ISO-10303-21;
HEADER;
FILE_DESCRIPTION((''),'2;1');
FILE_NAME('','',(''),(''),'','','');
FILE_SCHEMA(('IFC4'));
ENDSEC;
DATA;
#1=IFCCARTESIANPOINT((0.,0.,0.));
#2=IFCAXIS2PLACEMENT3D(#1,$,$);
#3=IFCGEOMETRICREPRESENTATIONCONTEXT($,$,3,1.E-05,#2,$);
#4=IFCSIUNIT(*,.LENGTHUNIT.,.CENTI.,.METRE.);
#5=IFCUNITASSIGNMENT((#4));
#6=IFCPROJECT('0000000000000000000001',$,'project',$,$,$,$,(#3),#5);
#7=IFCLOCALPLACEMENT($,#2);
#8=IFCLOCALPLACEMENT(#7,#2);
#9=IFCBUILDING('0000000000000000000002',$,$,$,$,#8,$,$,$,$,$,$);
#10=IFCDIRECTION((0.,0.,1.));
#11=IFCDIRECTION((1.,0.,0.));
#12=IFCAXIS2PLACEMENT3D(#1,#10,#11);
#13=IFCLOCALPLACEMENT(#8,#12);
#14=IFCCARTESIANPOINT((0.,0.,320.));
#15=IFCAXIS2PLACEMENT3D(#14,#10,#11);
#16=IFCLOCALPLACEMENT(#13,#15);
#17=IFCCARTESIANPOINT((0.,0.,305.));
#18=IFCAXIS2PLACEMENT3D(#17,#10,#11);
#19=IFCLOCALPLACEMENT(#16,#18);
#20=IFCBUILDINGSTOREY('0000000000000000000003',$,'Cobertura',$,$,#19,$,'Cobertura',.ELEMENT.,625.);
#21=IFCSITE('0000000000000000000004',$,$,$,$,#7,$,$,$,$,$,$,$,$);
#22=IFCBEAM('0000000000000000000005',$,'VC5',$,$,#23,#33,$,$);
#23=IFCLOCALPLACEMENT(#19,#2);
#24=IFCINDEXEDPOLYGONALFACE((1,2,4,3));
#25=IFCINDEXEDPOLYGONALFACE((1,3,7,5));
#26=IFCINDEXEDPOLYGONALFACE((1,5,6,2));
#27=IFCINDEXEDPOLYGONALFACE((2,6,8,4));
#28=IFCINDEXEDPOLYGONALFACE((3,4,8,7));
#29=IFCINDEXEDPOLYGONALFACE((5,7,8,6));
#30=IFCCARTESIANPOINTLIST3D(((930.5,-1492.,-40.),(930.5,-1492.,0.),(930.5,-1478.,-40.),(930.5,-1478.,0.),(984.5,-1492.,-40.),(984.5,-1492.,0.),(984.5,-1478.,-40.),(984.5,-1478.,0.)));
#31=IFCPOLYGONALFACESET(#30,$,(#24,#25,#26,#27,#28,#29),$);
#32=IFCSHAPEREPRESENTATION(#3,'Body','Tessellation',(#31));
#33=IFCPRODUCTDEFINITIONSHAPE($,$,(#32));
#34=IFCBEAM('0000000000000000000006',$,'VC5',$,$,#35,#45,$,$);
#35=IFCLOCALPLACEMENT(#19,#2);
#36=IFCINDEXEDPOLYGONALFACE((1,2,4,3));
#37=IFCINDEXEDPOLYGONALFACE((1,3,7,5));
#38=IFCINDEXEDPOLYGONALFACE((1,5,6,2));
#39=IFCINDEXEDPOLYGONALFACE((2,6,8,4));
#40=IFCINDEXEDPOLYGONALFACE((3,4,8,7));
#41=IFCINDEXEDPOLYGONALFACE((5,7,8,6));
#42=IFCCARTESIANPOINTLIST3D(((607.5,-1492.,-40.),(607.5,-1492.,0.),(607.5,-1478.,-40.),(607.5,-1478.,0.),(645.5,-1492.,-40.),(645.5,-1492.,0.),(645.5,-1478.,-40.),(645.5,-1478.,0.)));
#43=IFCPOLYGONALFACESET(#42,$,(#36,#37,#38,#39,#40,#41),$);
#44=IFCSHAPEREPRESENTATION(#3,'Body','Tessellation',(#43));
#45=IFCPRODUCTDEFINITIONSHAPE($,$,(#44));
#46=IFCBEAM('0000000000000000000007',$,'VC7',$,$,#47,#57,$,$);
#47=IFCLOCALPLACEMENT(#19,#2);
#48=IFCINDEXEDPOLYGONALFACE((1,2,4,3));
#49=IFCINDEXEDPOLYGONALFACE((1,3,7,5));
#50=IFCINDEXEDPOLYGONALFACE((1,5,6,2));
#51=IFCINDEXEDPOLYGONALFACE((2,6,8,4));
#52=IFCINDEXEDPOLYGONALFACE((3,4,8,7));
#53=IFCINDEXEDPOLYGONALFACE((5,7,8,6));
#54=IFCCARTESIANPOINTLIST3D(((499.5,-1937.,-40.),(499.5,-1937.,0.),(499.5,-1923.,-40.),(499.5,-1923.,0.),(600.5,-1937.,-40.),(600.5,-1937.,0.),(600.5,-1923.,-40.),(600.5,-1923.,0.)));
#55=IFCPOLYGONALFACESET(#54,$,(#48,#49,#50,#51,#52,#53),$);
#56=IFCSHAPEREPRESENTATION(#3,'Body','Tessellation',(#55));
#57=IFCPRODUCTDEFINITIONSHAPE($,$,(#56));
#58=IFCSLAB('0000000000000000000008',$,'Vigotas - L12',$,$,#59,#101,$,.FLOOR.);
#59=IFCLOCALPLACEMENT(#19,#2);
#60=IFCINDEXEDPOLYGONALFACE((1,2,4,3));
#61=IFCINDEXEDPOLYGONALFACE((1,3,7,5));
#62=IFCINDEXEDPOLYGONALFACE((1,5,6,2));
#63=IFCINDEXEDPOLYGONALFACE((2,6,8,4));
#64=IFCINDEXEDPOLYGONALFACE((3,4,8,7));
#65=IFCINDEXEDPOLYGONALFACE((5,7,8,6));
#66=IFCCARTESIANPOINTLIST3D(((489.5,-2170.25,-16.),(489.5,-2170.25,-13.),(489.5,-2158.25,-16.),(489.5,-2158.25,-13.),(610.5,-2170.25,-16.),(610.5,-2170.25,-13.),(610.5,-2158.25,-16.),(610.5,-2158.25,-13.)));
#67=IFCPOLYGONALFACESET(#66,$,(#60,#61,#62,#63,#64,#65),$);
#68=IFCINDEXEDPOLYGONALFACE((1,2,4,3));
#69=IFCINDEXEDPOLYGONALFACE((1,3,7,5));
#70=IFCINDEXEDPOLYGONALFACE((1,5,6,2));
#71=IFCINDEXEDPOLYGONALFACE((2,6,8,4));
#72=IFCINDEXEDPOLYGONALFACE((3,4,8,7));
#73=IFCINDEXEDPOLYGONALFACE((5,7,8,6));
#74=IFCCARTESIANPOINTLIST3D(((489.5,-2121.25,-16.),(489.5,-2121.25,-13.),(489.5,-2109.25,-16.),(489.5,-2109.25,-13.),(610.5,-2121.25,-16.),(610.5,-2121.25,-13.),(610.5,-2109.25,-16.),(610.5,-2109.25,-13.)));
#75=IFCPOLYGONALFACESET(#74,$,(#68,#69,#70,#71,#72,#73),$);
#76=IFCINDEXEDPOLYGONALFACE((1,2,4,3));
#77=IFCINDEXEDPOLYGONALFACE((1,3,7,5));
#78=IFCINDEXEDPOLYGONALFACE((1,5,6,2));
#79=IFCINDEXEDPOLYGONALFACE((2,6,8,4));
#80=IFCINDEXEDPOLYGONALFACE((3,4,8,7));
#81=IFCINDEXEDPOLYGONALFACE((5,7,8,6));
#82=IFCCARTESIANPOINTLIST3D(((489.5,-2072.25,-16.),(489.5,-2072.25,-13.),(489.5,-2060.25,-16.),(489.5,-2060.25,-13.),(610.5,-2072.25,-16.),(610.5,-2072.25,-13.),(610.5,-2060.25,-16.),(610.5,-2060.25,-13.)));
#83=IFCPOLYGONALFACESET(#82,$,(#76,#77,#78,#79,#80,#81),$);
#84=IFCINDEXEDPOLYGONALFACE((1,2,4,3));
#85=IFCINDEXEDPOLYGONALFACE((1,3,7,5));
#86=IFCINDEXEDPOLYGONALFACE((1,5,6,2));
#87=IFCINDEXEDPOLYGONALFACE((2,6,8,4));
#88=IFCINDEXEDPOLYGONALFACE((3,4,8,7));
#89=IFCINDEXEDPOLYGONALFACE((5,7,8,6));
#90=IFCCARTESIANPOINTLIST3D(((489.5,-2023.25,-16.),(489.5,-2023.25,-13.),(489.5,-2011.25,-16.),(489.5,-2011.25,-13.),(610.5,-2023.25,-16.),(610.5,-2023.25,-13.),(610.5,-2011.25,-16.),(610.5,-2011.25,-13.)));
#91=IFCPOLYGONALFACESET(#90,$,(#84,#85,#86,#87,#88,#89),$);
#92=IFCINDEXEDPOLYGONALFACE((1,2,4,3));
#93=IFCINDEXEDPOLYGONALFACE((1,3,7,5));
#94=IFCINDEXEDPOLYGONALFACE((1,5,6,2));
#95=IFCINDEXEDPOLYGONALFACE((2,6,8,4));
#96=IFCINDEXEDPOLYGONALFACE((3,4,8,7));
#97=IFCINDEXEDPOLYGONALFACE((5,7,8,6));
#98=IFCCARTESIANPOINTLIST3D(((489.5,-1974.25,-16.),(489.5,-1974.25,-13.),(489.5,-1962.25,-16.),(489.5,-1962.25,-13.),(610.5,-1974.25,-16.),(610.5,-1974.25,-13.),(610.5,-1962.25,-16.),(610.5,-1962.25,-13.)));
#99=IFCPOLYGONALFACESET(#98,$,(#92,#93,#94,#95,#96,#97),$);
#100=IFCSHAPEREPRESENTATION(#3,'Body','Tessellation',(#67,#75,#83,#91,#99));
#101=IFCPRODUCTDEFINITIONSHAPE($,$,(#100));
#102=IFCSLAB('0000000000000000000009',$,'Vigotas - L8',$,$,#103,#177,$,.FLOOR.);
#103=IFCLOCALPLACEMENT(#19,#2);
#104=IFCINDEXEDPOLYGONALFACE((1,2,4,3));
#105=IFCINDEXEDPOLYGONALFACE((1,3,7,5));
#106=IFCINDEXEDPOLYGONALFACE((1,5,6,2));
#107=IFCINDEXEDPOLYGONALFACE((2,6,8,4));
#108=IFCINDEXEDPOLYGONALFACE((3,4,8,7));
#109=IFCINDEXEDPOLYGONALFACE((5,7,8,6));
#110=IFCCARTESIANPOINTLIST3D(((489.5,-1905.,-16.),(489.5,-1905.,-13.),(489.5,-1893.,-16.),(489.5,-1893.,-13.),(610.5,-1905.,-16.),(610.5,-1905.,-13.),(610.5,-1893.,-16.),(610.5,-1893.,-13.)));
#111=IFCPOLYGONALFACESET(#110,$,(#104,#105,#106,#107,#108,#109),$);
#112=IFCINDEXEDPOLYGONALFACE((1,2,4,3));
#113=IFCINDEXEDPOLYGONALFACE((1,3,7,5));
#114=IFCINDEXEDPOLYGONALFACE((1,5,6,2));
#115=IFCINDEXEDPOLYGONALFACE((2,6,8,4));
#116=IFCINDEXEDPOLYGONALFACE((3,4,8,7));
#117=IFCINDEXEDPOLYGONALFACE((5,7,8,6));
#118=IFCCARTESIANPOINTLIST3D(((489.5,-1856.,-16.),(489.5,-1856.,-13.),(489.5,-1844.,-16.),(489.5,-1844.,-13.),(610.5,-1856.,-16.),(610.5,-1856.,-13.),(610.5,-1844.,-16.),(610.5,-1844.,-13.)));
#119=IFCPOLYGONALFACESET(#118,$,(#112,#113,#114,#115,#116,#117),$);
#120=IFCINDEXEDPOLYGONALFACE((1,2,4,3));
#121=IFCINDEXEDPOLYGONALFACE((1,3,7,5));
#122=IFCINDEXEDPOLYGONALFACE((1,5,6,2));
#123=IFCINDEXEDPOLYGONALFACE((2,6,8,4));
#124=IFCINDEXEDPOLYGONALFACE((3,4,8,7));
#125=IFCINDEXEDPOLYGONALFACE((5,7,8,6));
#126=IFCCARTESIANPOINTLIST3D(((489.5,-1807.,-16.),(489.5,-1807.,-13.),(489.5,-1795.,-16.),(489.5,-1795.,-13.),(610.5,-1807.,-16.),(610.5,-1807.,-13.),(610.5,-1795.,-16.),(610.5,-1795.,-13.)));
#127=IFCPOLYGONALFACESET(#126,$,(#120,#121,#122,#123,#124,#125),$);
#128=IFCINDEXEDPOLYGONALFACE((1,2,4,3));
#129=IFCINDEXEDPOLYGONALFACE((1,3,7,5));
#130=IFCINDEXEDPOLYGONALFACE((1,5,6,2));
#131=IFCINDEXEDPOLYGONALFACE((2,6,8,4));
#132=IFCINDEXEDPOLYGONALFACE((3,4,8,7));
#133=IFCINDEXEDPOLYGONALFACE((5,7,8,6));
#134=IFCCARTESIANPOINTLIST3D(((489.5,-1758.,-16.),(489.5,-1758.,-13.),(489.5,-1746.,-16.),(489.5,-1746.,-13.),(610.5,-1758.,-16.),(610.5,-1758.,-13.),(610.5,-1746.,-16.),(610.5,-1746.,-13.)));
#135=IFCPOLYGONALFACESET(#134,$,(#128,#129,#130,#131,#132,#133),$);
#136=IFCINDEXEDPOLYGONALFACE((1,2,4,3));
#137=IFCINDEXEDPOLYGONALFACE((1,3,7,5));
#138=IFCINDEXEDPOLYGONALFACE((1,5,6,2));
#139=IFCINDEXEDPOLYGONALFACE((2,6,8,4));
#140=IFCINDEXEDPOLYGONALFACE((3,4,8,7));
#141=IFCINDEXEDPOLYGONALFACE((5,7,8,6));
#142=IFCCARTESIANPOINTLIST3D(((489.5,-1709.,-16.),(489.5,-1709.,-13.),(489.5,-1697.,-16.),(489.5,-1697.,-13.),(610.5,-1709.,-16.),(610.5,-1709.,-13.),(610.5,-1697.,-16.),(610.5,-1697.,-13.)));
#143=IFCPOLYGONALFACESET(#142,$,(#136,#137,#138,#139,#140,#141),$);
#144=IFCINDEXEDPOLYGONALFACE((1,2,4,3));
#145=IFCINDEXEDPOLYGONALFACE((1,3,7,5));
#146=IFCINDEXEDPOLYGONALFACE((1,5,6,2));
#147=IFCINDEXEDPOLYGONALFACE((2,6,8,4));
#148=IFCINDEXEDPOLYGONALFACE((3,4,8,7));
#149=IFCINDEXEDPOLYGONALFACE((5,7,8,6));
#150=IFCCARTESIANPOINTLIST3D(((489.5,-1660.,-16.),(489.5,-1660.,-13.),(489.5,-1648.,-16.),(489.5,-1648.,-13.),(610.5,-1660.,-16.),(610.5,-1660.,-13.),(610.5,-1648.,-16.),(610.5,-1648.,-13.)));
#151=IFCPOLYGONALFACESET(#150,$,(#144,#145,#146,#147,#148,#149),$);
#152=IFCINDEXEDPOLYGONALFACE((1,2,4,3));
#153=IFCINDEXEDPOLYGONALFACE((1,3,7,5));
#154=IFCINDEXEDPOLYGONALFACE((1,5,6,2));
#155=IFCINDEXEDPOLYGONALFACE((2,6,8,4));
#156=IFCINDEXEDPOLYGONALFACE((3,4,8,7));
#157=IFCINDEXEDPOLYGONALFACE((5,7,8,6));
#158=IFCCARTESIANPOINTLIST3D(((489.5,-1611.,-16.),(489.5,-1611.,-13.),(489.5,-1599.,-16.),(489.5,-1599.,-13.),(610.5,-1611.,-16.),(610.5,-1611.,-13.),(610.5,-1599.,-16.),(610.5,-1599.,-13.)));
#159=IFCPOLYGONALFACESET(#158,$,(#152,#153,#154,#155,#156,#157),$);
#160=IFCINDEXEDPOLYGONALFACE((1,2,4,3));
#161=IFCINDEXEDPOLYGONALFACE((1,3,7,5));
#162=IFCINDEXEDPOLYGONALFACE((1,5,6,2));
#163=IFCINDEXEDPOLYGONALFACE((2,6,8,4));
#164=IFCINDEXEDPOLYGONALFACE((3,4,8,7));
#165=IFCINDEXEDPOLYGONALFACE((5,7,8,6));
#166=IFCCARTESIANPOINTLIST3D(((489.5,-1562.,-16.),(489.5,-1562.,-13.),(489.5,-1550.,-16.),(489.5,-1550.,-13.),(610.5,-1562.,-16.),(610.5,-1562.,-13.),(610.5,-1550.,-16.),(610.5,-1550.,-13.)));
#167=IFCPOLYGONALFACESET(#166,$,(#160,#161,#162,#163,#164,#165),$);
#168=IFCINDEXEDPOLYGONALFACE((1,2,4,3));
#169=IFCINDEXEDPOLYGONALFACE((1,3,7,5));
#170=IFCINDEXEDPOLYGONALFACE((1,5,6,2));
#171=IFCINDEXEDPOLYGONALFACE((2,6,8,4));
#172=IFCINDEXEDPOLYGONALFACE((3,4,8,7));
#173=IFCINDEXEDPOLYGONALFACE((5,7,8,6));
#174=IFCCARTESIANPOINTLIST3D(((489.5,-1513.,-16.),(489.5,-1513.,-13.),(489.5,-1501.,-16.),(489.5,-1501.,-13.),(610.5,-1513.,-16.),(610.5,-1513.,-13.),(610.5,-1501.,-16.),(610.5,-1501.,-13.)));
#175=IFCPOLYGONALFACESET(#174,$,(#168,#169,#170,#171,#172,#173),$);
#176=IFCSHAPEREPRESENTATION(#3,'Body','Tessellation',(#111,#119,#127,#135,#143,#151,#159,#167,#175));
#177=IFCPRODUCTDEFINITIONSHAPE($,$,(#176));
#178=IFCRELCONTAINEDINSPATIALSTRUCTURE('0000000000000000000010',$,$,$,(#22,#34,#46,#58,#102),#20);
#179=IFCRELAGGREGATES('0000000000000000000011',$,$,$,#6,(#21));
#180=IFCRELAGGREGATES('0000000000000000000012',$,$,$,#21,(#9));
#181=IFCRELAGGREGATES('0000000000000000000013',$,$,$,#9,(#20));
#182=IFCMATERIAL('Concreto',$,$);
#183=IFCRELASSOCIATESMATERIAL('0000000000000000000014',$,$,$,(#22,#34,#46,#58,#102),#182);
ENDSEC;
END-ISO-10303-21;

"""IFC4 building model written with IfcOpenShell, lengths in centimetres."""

from ifc_helpers import new_model, si_unit, frame, origin, origin_with_axes, place, context, project, spatial, polyline, outline, extrude, material, element, save


model = new_model("IFC4")

# Units and contexts
context_of_model = context(None, 3, precision=1e-05, world=origin())
ifc_project = project(units=[si_unit("LENGTHUNIT", "METRE", prefix="CENTI")], contexts=[context_of_model])

# Site, building, storey
site_placement = place(None, origin())
site = spatial("IfcSite", under=ifc_project, at=site_placement)
building_placement = place(site_placement, origin())
building = spatial("IfcBuilding", under=site, at=building_placement)
placement_1 = place(building_placement, origin_with_axes())
placement_2 = place(placement_1, frame((0.0, 0.0, 320.0), z_axis=(0.0, 0.0, 1.0), x_axis=(1.0, 0.0, 0.0)))
storey_placement = place(placement_2, frame((0.0, 0.0, 305.0), z_axis=(0.0, 0.0, 1.0), x_axis=(1.0, 0.0, 0.0)))
storey = spatial("IfcBuildingStorey", under=building, at=storey_placement, Name="Cobertura", LongName="Cobertura", CompositionType="ELEMENT", Elevation=625.0)

# Shared definitions
ifc_material_1 = material(Name="Concreto")

# Beams
beam_1_placement = place(storey_placement, frame((957.5, -1485.0, 0.0), z_axis=(0.0, 0.0, 1.0), x_axis=(1.0, 0.0, 0.0)))
element("IfcBeam", 1, at=beam_1_placement, inside=storey, material=ifc_material_1, Name="VC5", context=context_of_model, shape_type="SolidModel", body=[
    extrude(outline(polyline([(-7.0, -20.0), (7.0, -20.0), (7.0, 20.0), (-7.0, 20.0), (-7.0, -20.0)])), frame((-27.0, 0.0, -20.0), z_axis=(1.0, 0.0, 0.0), x_axis=(0.0, -1.0, 0.0)), (0.0, 0.0, 1.0), 54.0),
])
beam_2_placement = place(storey_placement, frame((626.5, -1485.0, 0.0), z_axis=(0.0, 0.0, 1.0), x_axis=(1.0, 0.0, 0.0)))
element("IfcBeam", 2, at=beam_2_placement, inside=storey, material=ifc_material_1, Name="VC5", context=context_of_model, shape_type="SolidModel", body=[
    extrude(outline(polyline([(-7.0, -20.0), (7.0, -20.0), (7.0, 20.0), (-7.0, 20.0), (-7.0, -20.0)])), frame((-19.0, 0.0, -20.0), z_axis=(1.0, 0.0, 0.0), x_axis=(0.0, -1.0, 0.0)), (0.0, 0.0, 1.0), 38.0),
])
beam_3_placement = place(storey_placement, frame((550.0, -1930.0, 0.0), z_axis=(0.0, 0.0, 1.0), x_axis=(1.0, 0.0, 0.0)))
element("IfcBeam", 3, at=beam_3_placement, inside=storey, material=ifc_material_1, Name="VC7", context=context_of_model, shape_type="SolidModel", body=[
    extrude(outline(polyline([(-7.0, -20.0), (7.0, -20.0), (7.0, 20.0), (-7.0, 20.0), (-7.0, -20.0)])), frame((-50.5, 0.0, -20.0), z_axis=(1.0, 0.0, 0.0), x_axis=(0.0, -1.0, 0.0)), (0.0, 0.0, 1.0), 101.0),
])

# Slabs
slab_1_placement = place(storey_placement, frame((550.0, -2066.25, -13.0), z_axis=(0.0, 0.0, 1.0), x_axis=(1.0, 0.0, 0.0)))
element("IfcSlab", 4, at=slab_1_placement, inside=storey, material=ifc_material_1, Name="Vigotas - L12", PredefinedType="FLOOR", context=context_of_model, shape_type="SolidModel", body=[
    extrude(outline(polyline([(6.0, 1.5), (-6.0, 1.5), (-6.0, -1.5), (6.0, -1.5), (6.0, 1.5), (6.0, 1.5)])), frame((-60.5, -98.0, -1.5), z_axis=(1.0, 0.0, 0.0), x_axis=(0.0, -1.0, 0.0)), (0.0, 0.0, 1.0), 121.0),
    extrude(outline(polyline([(6.0, 1.5), (-6.0, 1.5), (-6.0, -1.5), (6.0, -1.5), (6.0, 1.5), (6.0, 1.5)])), frame((-60.5, -49.0, -1.5), z_axis=(1.0, 0.0, 0.0), x_axis=(0.0, -1.0, 0.0)), (0.0, 0.0, 1.0), 121.0),
    extrude(outline(polyline([(6.0, 1.5), (-6.0, 1.5), (-6.0, -1.5), (6.0, -1.5), (6.0, 1.5), (6.0, 1.5)])), frame((-60.5, 0.0, -1.5), z_axis=(1.0, 0.0, 0.0), x_axis=(0.0, -1.0, 0.0)), (0.0, 0.0, 1.0), 121.0),
    extrude(outline(polyline([(6.0, 1.5), (-6.0, 1.5), (-6.0, -1.5), (6.0, -1.5), (6.0, 1.5), (6.0, 1.5)])), frame((-60.5, 49.0, -1.5), z_axis=(1.0, 0.0, 0.0), x_axis=(0.0, -1.0, 0.0)), (0.0, 0.0, 1.0), 121.0),
    extrude(outline(polyline([(6.0, 1.5), (-6.0, 1.5), (-6.0, -1.5), (6.0, -1.5), (6.0, 1.5), (6.0, 1.5)])), frame((-60.5, 98.0, -1.5), z_axis=(1.0, 0.0, 0.0), x_axis=(0.0, -1.0, 0.0)), (0.0, 0.0, 1.0), 121.0),
])
slab_2_placement = place(storey_placement, frame((550.0, -1703.0, -13.0), z_axis=(0.0, 0.0, 1.0), x_axis=(1.0, 0.0, 0.0)))
element("IfcSlab", 5, at=slab_2_placement, inside=storey, material=ifc_material_1, Name="Vigotas - L8", PredefinedType="FLOOR", context=context_of_model, shape_type="SolidModel", body=[
    extrude(outline(polyline([(6.0, 1.5), (-6.0, 1.5), (-6.0, -1.5), (6.0, -1.5), (6.0, 1.5), (6.0, 1.5)])), frame((-60.5, -196.0, -1.5), z_axis=(1.0, 0.0, 0.0), x_axis=(0.0, -1.0, 0.0)), (0.0, 0.0, 1.0), 121.0),
    extrude(outline(polyline([(6.0, 1.5), (-6.0, 1.5), (-6.0, -1.5), (6.0, -1.5), (6.0, 1.5), (6.0, 1.5)])), frame((-60.5, -147.0, -1.5), z_axis=(1.0, 0.0, 0.0), x_axis=(0.0, -1.0, 0.0)), (0.0, 0.0, 1.0), 121.0),
    extrude(outline(polyline([(6.0, 1.5), (-6.0, 1.5), (-6.0, -1.5), (6.0, -1.5), (6.0, 1.5), (6.0, 1.5)])), frame((-60.5, -98.0, -1.5), z_axis=(1.0, 0.0, 0.0), x_axis=(0.0, -1.0, 0.0)), (0.0, 0.0, 1.0), 121.0),
    extrude(outline(polyline([(6.0, 1.5), (-6.0, 1.5), (-6.0, -1.5), (6.0, -1.5), (6.0, 1.5), (6.0, 1.5)])), frame((-60.5, -49.0, -1.5), z_axis=(1.0, 0.0, 0.0), x_axis=(0.0, -1.0, 0.0)), (0.0, 0.0, 1.0), 121.0),
    extrude(outline(polyline([(6.0, 1.5), (-6.0, 1.5), (-6.0, -1.5), (6.0, -1.5), (6.0, 1.5), (6.0, 1.5)])), frame((-60.5, 0.0, -1.5), z_axis=(1.0, 0.0, 0.0), x_axis=(0.0, -1.0, 0.0)), (0.0, 0.0, 1.0), 121.0),
    extrude(outline(polyline([(6.0, 1.5), (-6.0, 1.5), (-6.0, -1.5), (6.0, -1.5), (6.0, 1.5), (6.0, 1.5)])), frame((-60.5, 49.0, -1.5), z_axis=(1.0, 0.0, 0.0), x_axis=(0.0, -1.0, 0.0)), (0.0, 0.0, 1.0), 121.0),
    extrude(outline(polyline([(6.0, 1.5), (-6.0, 1.5), (-6.0, -1.5), (6.0, -1.5), (6.0, 1.5), (6.0, 1.5)])), frame((-60.5, 98.0, -1.5), z_axis=(1.0, 0.0, 0.0), x_axis=(0.0, -1.0, 0.0)), (0.0, 0.0, 1.0), 121.0),
    extrude(outline(polyline([(6.0, 1.5), (-6.0, 1.5), (-6.0, -1.5), (6.0, -1.5), (6.0, 1.5), (6.0, 1.5)])), frame((-60.5, 147.0, -1.5), z_axis=(1.0, 0.0, 0.0), x_axis=(0.0, -1.0, 0.0)), (0.0, 0.0, 1.0), 121.0),
    extrude(outline(polyline([(6.0, 1.5), (-6.0, 1.5), (-6.0, -1.5), (6.0, -1.5), (6.0, 1.5), (6.0, 1.5)])), frame((-60.5, 196.0, -1.5), z_axis=(1.0, 0.0, 0.0), x_axis=(0.0, -1.0, 0.0)), (0.0, 0.0, 1.0), 121.0),
])

save(model, "model.ifc")
